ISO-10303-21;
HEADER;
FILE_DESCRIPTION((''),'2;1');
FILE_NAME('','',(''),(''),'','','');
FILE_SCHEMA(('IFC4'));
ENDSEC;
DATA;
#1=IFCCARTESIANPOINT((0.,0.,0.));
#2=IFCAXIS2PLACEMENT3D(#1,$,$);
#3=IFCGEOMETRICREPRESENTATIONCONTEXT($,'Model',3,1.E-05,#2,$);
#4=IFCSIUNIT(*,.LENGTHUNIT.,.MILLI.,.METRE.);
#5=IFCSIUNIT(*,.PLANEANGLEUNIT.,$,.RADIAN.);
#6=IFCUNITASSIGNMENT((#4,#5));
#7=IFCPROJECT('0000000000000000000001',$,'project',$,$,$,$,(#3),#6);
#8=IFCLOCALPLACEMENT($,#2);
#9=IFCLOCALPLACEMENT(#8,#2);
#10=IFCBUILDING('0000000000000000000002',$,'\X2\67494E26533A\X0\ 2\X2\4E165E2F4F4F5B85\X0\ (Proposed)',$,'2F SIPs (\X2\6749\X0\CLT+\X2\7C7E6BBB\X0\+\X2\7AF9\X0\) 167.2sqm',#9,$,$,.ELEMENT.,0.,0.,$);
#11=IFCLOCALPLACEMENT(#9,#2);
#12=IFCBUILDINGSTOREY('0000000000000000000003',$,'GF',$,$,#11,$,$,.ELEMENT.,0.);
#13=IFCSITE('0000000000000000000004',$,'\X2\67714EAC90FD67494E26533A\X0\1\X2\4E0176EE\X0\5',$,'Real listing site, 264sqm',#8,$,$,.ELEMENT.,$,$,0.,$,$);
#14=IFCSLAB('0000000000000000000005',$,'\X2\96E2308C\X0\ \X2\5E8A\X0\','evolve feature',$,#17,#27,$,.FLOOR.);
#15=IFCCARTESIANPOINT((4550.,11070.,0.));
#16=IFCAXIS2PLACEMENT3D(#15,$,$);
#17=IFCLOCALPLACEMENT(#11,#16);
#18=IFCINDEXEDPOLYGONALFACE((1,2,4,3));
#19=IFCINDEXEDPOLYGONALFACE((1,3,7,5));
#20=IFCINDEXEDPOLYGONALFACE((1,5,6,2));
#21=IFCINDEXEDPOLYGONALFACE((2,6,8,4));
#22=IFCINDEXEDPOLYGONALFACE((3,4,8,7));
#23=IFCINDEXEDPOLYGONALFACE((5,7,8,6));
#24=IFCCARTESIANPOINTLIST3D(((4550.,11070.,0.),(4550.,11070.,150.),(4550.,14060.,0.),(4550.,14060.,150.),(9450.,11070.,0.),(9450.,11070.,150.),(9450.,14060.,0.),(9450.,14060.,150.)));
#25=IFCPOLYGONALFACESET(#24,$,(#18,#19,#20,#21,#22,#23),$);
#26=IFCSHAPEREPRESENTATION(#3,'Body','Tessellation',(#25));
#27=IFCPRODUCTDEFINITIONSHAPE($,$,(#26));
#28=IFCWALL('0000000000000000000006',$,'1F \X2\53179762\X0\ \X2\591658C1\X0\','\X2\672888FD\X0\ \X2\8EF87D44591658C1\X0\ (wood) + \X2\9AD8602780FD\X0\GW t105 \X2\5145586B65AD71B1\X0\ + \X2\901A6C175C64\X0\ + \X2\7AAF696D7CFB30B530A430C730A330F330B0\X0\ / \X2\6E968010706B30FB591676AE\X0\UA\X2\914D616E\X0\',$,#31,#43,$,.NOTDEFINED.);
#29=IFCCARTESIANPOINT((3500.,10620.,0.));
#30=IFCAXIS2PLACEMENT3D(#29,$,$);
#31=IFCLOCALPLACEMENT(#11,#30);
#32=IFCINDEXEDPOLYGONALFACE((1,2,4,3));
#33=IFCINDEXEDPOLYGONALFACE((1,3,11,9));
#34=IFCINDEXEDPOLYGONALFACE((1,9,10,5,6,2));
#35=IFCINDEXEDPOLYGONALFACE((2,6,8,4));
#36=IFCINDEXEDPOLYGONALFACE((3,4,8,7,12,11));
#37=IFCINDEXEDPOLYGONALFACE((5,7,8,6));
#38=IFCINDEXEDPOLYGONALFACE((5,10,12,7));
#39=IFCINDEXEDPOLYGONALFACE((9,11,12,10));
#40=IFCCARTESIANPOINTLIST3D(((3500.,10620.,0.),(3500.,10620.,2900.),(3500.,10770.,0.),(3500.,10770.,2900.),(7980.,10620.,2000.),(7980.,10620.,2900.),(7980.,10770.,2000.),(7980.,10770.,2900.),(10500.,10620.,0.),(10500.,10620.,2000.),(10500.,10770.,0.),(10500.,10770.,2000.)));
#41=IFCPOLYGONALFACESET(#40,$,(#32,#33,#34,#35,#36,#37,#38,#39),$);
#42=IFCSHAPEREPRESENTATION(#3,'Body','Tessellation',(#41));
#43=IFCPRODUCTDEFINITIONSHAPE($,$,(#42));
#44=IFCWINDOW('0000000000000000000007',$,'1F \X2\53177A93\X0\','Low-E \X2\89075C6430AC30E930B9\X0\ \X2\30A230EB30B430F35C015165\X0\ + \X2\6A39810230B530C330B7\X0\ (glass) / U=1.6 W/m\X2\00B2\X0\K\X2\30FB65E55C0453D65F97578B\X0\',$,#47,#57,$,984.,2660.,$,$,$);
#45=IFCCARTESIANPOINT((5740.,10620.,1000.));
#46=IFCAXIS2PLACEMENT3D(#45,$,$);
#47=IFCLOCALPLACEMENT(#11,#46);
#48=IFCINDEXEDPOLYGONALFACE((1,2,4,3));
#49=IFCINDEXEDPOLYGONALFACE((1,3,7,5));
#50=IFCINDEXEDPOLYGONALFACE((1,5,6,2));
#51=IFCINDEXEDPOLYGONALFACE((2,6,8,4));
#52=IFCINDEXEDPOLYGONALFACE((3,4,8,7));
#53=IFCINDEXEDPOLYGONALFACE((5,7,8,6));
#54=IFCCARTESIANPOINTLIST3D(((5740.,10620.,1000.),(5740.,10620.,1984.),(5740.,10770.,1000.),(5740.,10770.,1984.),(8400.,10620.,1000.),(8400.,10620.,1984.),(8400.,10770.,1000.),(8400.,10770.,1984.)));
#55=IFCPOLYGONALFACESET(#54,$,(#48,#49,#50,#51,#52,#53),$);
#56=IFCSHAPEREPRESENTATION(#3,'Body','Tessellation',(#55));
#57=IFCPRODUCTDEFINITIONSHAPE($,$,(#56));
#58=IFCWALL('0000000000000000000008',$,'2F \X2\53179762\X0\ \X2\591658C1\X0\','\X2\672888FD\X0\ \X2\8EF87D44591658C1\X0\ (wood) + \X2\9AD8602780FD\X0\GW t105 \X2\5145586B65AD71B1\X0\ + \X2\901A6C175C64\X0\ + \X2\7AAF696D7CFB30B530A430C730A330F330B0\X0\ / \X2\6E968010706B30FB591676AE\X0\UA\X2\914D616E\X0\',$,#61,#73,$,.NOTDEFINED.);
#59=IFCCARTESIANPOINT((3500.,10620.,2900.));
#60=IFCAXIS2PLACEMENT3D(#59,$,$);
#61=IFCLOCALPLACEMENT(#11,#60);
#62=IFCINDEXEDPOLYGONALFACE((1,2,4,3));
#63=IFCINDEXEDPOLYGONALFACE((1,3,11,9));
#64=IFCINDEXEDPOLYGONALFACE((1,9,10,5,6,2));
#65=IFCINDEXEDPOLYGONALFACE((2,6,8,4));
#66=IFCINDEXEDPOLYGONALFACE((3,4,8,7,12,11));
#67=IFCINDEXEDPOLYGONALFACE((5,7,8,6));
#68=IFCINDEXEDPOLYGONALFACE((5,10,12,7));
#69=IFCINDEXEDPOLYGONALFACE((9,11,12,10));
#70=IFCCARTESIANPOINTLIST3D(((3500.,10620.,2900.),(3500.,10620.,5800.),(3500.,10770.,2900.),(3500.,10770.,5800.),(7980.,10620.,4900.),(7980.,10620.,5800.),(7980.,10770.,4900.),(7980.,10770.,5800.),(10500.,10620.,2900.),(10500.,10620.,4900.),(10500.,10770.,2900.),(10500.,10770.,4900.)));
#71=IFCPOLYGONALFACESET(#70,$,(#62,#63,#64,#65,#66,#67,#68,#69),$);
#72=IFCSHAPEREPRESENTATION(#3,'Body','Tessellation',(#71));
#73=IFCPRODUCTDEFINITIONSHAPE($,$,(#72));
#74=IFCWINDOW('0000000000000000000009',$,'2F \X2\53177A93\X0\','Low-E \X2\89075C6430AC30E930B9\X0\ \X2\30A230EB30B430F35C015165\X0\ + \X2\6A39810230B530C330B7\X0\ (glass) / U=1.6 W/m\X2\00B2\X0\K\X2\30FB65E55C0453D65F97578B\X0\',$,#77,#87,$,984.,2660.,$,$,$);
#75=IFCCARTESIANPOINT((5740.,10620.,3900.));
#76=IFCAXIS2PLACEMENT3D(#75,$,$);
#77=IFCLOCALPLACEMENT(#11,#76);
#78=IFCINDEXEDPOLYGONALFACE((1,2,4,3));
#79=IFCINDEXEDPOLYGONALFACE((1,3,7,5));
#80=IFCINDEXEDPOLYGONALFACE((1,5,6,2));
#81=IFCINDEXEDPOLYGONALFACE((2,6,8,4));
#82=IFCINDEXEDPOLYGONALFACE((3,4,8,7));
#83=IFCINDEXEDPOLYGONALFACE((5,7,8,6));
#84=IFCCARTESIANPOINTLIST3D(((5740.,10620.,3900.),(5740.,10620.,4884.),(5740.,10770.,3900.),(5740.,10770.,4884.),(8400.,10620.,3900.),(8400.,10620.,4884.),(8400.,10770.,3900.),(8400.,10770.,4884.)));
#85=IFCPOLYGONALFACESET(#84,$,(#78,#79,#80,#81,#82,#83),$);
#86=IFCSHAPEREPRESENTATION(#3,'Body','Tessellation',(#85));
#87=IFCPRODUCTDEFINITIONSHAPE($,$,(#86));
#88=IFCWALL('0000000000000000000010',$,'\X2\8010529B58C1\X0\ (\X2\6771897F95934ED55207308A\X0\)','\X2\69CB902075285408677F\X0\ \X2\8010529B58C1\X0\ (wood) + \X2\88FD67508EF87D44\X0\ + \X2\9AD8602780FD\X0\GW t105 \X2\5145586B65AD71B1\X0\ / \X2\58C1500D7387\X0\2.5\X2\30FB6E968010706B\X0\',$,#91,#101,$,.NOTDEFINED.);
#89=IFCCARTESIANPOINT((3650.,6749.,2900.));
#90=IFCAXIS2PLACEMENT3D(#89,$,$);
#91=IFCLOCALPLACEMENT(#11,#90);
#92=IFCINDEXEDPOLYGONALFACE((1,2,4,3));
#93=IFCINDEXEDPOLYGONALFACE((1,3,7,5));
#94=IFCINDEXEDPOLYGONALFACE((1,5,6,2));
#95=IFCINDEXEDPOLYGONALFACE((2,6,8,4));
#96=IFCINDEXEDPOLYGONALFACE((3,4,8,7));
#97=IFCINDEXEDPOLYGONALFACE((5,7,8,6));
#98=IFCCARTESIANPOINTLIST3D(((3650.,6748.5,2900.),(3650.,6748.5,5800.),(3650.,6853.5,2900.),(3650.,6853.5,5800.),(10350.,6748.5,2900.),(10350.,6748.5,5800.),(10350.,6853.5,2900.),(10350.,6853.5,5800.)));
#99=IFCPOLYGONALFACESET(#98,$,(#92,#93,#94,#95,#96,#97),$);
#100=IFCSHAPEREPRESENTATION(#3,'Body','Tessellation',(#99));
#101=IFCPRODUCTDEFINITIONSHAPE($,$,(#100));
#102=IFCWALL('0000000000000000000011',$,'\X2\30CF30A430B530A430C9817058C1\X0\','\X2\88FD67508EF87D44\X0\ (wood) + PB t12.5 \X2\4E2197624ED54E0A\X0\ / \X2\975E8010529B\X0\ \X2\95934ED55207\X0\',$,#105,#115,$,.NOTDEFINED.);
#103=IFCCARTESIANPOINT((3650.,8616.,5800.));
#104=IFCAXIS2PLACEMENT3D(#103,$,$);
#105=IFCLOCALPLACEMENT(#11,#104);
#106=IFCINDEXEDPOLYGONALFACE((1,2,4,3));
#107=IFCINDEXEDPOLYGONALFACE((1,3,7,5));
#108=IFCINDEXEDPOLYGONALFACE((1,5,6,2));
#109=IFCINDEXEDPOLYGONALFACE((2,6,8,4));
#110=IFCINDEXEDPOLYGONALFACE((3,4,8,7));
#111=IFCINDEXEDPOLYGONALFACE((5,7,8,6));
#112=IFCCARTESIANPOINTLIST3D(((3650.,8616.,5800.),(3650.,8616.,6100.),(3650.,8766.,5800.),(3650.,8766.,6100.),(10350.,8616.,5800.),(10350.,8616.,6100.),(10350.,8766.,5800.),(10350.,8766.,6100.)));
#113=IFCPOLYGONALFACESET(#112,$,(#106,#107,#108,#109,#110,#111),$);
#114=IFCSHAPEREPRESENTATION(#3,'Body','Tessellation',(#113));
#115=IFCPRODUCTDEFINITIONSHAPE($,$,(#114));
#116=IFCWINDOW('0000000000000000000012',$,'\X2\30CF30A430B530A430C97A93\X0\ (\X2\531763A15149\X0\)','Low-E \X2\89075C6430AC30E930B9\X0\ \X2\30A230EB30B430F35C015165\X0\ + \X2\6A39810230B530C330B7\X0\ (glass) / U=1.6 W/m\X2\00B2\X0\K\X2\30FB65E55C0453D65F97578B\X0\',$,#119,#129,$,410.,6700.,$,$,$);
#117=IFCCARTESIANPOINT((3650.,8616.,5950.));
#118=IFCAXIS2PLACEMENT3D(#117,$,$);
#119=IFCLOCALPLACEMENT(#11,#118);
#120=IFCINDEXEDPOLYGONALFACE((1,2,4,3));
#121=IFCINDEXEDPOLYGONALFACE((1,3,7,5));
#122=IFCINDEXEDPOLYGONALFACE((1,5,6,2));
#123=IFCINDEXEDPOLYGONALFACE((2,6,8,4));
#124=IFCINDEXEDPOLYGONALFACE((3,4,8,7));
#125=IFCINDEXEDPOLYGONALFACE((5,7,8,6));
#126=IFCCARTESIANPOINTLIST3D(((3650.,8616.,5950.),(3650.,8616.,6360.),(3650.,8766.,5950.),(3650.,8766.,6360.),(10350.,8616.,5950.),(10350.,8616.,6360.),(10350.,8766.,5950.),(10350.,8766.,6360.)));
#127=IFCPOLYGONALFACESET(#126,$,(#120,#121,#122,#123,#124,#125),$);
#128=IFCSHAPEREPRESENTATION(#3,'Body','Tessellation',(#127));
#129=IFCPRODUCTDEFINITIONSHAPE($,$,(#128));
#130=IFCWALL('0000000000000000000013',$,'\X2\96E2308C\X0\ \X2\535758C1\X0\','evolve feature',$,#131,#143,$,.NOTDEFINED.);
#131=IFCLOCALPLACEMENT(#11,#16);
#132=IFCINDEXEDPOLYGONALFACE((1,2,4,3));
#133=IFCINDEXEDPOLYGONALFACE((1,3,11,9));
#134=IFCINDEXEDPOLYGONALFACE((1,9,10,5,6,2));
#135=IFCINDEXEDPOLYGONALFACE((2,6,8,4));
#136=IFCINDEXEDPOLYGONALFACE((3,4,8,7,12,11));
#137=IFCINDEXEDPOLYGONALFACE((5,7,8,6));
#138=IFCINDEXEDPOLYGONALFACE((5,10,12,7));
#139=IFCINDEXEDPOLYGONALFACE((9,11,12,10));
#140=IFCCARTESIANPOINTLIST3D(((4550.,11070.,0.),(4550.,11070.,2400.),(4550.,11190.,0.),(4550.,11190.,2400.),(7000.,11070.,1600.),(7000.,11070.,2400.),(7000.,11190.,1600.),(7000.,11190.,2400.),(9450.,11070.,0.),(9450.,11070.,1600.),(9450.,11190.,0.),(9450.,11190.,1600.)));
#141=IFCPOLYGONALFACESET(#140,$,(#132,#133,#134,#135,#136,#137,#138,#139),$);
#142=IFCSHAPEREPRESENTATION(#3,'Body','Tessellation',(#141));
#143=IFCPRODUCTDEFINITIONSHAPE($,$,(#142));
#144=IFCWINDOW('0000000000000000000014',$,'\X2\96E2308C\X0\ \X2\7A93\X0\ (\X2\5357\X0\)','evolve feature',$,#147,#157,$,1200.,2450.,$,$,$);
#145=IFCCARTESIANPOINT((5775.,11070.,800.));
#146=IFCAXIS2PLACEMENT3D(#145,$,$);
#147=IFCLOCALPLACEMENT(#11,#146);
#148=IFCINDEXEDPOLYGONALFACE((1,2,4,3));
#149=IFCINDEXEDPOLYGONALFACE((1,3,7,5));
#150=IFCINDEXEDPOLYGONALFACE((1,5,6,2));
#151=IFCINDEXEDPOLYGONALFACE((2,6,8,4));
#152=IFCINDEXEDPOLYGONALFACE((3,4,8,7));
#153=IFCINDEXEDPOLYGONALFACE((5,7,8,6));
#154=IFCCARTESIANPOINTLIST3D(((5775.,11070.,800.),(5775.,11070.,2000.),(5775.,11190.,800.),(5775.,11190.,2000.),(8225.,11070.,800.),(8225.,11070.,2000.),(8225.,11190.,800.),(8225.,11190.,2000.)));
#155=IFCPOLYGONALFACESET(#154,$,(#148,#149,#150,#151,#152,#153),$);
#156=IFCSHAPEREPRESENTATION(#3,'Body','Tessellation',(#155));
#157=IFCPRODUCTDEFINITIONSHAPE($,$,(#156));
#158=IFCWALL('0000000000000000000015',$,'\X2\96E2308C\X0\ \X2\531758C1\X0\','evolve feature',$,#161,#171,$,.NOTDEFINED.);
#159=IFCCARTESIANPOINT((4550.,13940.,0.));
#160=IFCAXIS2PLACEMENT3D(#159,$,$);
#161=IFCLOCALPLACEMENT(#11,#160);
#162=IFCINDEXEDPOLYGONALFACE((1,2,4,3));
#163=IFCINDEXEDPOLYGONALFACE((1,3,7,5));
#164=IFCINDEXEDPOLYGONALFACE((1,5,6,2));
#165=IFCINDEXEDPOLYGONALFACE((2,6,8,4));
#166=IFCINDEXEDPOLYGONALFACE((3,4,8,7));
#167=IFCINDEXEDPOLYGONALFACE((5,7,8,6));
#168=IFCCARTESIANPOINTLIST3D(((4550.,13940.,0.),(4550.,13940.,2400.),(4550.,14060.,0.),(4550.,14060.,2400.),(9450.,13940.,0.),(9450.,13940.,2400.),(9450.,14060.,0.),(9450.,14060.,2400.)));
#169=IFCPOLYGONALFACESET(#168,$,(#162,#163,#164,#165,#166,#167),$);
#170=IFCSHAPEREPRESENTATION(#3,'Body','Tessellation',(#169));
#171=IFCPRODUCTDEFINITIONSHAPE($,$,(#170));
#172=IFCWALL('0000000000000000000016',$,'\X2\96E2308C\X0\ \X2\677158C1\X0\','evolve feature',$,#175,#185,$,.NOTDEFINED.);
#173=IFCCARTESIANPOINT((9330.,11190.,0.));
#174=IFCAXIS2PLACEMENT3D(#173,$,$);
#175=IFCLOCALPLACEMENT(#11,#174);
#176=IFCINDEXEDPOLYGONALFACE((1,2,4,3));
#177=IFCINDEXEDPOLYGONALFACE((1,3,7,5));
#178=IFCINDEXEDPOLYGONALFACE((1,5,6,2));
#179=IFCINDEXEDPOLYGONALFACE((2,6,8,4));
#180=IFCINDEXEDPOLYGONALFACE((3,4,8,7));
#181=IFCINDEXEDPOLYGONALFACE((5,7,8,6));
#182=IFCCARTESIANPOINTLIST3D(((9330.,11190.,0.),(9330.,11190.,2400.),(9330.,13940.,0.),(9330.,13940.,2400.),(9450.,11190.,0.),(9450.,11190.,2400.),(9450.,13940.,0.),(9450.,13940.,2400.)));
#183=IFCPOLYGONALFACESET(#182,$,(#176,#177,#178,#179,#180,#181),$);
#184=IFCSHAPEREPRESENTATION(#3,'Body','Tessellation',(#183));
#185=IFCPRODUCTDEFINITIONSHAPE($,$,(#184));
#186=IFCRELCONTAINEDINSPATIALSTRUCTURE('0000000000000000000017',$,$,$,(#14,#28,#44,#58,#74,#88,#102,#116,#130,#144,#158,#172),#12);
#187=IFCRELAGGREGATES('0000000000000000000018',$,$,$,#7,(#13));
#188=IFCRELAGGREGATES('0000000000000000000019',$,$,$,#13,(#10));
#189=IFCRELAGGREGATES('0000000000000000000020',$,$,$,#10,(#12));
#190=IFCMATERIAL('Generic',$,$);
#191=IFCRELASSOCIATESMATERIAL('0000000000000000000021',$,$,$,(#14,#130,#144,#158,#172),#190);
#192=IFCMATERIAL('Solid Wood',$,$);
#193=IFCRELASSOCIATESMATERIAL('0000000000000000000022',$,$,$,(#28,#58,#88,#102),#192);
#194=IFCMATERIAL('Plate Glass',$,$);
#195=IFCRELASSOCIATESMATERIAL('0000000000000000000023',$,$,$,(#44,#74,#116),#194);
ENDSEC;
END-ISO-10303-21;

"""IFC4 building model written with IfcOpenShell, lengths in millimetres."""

from ifc_helpers import new_model, si_unit, frame, frame_2d, origin, place, context, project, spatial, rectangle, extrude, material, element, fill, save


model = new_model("IFC4")

# Units and contexts
model_context = context("Model", 3, precision=1e-05, world=origin())
ifc_project = project(units=[si_unit("LENGTHUNIT", "METRE", prefix="MILLI"), si_unit("PLANEANGLEUNIT", "RADIAN")], contexts=[model_context])

# Site, building, storey
site_placement = place(None, origin())
site = spatial("IfcSite", under=ifc_project, at=site_placement, Name="東京都杉並区1丁目5", ObjectType="Real listing site, 264sqm", CompositionType="ELEMENT", RefElevation=0.0)
building_placement = place(site_placement, origin())
building = spatial("IfcBuilding", under=site, at=building_placement, Name="杉並区 2世帯住宅 (Proposed)", ObjectType="2F SIPs (杉CLT+籾殻+竹) 167.2sqm", CompositionType="ELEMENT", ElevationOfRefHeight=0.0, ElevationOfTerrain=0.0)
storey_placement = place(building_placement, origin())
storey = spatial("IfcBuildingStorey", under=building, at=storey_placement, Name="GF", CompositionType="ELEMENT", Elevation=0.0)

# Slab
ifc_material_1 = material(Name="Generic")
slab_placement = place(storey_placement, frame((4550.0, 11070.0, 0.0)))
element("IfcSlab", 1, at=slab_placement, inside=storey, material=ifc_material_1, Name="離れ 床", Description="evolve feature", PredefinedType="FLOOR", context=model_context, shape_type="SweptSolid", body=[
    extrude(rectangle(XDim=4900.0, YDim=2990.0, at=frame_2d((2450.0, 1495.0))), frame((4550.0, 11070.0, 0.0)), (0.0, 0.0, 1.0), 150.0),
])

# Wall, opening, window
ifc_material_2 = material(Name="Solid Wood")
wall_1_placement = place(storey_placement, frame((3500.0, 10620.0, 0.0)))
wall_1 = element("IfcWall", 2, at=wall_1_placement, inside=storey, material=ifc_material_2, Name="1F 北面 外壁", Description="木製 軸組外壁 (wood) + 高性能GW t105 充填断熱 + 通気層 + 窯業系サイディング / 準耐火・外皮UA配慮", PredefinedType="NOTDEFINED", context=model_context, shape_type="SweptSolid", body=[
    extrude(rectangle(XDim=7000.0, YDim=150.0, at=frame_2d((3500.0, 75.0))), frame((3500.0, 10620.0, 0.0)), (0.0, 0.0, 1.0), 2900.0),
])
opening_1_placement = place(storey_placement, frame((5740.0, 10620.0, 1000.0)))
opening_1 = element("IfcOpeningElement", 3, at=opening_1_placement, cuts=wall_1, PredefinedType="NOTDEFINED", context=model_context, shape_type="SweptSolid", body=[
    extrude(rectangle(XDim=2660.0, YDim=150.0, at=frame_2d((1330.0, 75.0))), frame((5740.0, 10620.0, 1000.0)), (0.0, 0.0, 1.0), 984.0),
])
ifc_material_3 = material(Name="Plate Glass")
window_1_placement = place(storey_placement, frame((5740.0, 10620.0, 1000.0)))
window_1 = element("IfcWindow", 4, at=window_1_placement, inside=storey, material=ifc_material_3, Name="1F 北窓", Description="Low-E 複層ガラス アルゴン封入 + 樹脂サッシ (glass) / U=1.6 W/m²K・日射取得型", OverallHeight=984.0, OverallWidth=2660.0, context=model_context, shape_type="SweptSolid", body=[
    extrude(rectangle(XDim=2660.0, YDim=150.0, at=frame_2d((1330.0, 75.0))), frame((5740.0, 10620.0, 1000.0)), (0.0, 0.0, 1.0), 984.0),
])
fill(opening_1, window_1)

# Wall, opening, window
wall_2_placement = place(storey_placement, frame((3500.0, 10620.0, 2900.0)))
wall_2 = element("IfcWall", 5, at=wall_2_placement, inside=storey, material=ifc_material_2, Name="2F 北面 外壁", Description="木製 軸組外壁 (wood) + 高性能GW t105 充填断熱 + 通気層 + 窯業系サイディング / 準耐火・外皮UA配慮", PredefinedType="NOTDEFINED", context=model_context, shape_type="SweptSolid", body=[
    extrude(rectangle(XDim=7000.0, YDim=150.0, at=frame_2d((3500.0, 75.0))), frame((3500.0, 10620.0, 2900.0)), (0.0, 0.0, 1.0), 2900.0),
])
opening_2_placement = place(storey_placement, frame((5740.0, 10620.0, 3900.0)))
opening_2 = element("IfcOpeningElement", 6, at=opening_2_placement, cuts=wall_2, PredefinedType="NOTDEFINED", context=model_context, shape_type="SweptSolid", body=[
    extrude(rectangle(XDim=2660.0, YDim=150.0, at=frame_2d((1330.0, 75.0))), frame((5740.0, 10620.0, 3900.0)), (0.0, 0.0, 1.0), 984.0),
])
window_2_placement = place(storey_placement, frame((5740.0, 10620.0, 3900.0)))
window_2 = element("IfcWindow", 7, at=window_2_placement, inside=storey, material=ifc_material_3, Name="2F 北窓", Description="Low-E 複層ガラス アルゴン封入 + 樹脂サッシ (glass) / U=1.6 W/m²K・日射取得型", OverallHeight=984.0, OverallWidth=2660.0, context=model_context, shape_type="SweptSolid", body=[
    extrude(rectangle(XDim=2660.0, YDim=150.0, at=frame_2d((1330.0, 75.0))), frame((5740.0, 10620.0, 3900.0)), (0.0, 0.0, 1.0), 984.0),
])
fill(opening_2, window_2)

# Wall
wall_3_placement = place(storey_placement, frame((3650.0, 6749.0, 2900.0)))
element("IfcWall", 8, at=wall_3_placement, inside=storey, material=ifc_material_2, Name="耐力壁 (東西間仕切り)", Description="構造用合板 耐力壁 (wood) + 製材軸組 + 高性能GW t105 充填断熱 / 壁倍率2.5・準耐火", PredefinedType="NOTDEFINED", context=model_context, shape_type="SweptSolid", body=[
    extrude(rectangle(XDim=6700.0, YDim=105.0, at=frame_2d((3350.0, 52.0))), frame((3650.0, 6749.0, 2900.0)), (0.0, 0.0, 1.0), 2900.0),
])

# Walls, openings, windows
wall_4_placement = place(storey_placement, frame((3650.0, 8616.0, 5800.0)))
wall_4 = element("IfcWall", 9, at=wall_4_placement, inside=storey, material=ifc_material_2, Name="ハイサイド腰壁", Description="製材軸組 (wood) + PB t12.5 両面仕上 / 非耐力 間仕切", PredefinedType="NOTDEFINED", context=model_context, shape_type="SweptSolid", body=[
    extrude(rectangle(XDim=6700.0, YDim=150.0, at=frame_2d((3350.0, 75.0))), frame((3650.0, 8616.0, 5800.0)), (0.0, 0.0, 1.0), 700.0),
])
opening_3_placement = place(storey_placement, frame((3650.0, 8616.0, 5950.0)))
opening_3 = element("IfcOpeningElement", 10, at=opening_3_placement, cuts=wall_4, PredefinedType="NOTDEFINED", context=model_context, shape_type="SweptSolid", body=[
    extrude(rectangle(XDim=6700.0, YDim=150.0, at=frame_2d((3350.0, 75.0))), frame((3650.0, 8616.0, 5950.0)), (0.0, 0.0, 1.0), 410.0),
])
window_3_placement = place(storey_placement, frame((3650.0, 8616.0, 5950.0)))
window_3 = element("IfcWindow", 11, at=window_3_placement, inside=storey, material=ifc_material_3, Name="ハイサイド窓 (北採光)", Description="Low-E 複層ガラス アルゴン封入 + 樹脂サッシ (glass) / U=1.6 W/m²K・日射取得型", OverallHeight=410.0, OverallWidth=6700.0, context=model_context, shape_type="SweptSolid", body=[
    extrude(rectangle(XDim=6700.0, YDim=150.0, at=frame_2d((3350.0, 75.0))), frame((3650.0, 8616.0, 5950.0)), (0.0, 0.0, 1.0), 410.0),
])
fill(opening_3, window_3)
wall_5_placement = place(storey_placement, frame((4550.0, 11070.0, 0.0)))
wall_5 = element("IfcWall", 12, at=wall_5_placement, inside=storey, material=ifc_material_1, Name="離れ 南壁", Description="evolve feature", PredefinedType="NOTDEFINED", context=model_context, shape_type="SweptSolid", body=[
    extrude(rectangle(XDim=4900.0, YDim=120.0, at=frame_2d((2450.0, 60.0))), frame((4550.0, 11070.0, 0.0)), (0.0, 0.0, 1.0), 2400.0),
])
opening_4_placement = place(storey_placement, frame((5775.0, 11070.0, 800.0)))
opening_4 = element("IfcOpeningElement", 13, at=opening_4_placement, cuts=wall_5, PredefinedType="NOTDEFINED", context=model_context, shape_type="SweptSolid", body=[
    extrude(rectangle(XDim=2450.0, YDim=120.0, at=frame_2d((1225.0, 60.0))), frame((5775.0, 11070.0, 800.0)), (0.0, 0.0, 1.0), 1200.0),
])
window_4_placement = place(storey_placement, frame((5775.0, 11070.0, 800.0)))
window_4 = element("IfcWindow", 14, at=window_4_placement, inside=storey, material=ifc_material_1, Name="離れ 窓 (南)", Description="evolve feature", OverallHeight=1200.0, OverallWidth=2450.0, context=model_context, shape_type="SweptSolid", body=[
    extrude(rectangle(XDim=2450.0, YDim=120.0, at=frame_2d((1225.0, 60.0))), frame((5775.0, 11070.0, 800.0)), (0.0, 0.0, 1.0), 1200.0),
])
fill(opening_4, window_4)

# Walls
wall_6_placement = place(storey_placement, frame((4550.0, 13940.0, 0.0)))
element("IfcWall", 15, at=wall_6_placement, inside=storey, material=ifc_material_1, Name="離れ 北壁", Description="evolve feature", PredefinedType="NOTDEFINED", context=model_context, shape_type="SweptSolid", body=[
    extrude(rectangle(XDim=4900.0, YDim=120.0, at=frame_2d((2450.0, 60.0))), frame((4550.0, 13940.0, 0.0)), (0.0, 0.0, 1.0), 2400.0),
])
wall_7_placement = place(storey_placement, frame((9330.0, 11190.0, 0.0)))
element("IfcWall", 16, at=wall_7_placement, inside=storey, material=ifc_material_1, Name="離れ 東壁", Description="evolve feature", PredefinedType="NOTDEFINED", context=model_context, shape_type="SweptSolid", body=[
    extrude(rectangle(XDim=120.0, YDim=2750.0, at=frame_2d((60.0, 1375.0))), frame((9330.0, 11190.0, 0.0)), (0.0, 0.0, 1.0), 2400.0),
])

save(model, "model.ifc")
